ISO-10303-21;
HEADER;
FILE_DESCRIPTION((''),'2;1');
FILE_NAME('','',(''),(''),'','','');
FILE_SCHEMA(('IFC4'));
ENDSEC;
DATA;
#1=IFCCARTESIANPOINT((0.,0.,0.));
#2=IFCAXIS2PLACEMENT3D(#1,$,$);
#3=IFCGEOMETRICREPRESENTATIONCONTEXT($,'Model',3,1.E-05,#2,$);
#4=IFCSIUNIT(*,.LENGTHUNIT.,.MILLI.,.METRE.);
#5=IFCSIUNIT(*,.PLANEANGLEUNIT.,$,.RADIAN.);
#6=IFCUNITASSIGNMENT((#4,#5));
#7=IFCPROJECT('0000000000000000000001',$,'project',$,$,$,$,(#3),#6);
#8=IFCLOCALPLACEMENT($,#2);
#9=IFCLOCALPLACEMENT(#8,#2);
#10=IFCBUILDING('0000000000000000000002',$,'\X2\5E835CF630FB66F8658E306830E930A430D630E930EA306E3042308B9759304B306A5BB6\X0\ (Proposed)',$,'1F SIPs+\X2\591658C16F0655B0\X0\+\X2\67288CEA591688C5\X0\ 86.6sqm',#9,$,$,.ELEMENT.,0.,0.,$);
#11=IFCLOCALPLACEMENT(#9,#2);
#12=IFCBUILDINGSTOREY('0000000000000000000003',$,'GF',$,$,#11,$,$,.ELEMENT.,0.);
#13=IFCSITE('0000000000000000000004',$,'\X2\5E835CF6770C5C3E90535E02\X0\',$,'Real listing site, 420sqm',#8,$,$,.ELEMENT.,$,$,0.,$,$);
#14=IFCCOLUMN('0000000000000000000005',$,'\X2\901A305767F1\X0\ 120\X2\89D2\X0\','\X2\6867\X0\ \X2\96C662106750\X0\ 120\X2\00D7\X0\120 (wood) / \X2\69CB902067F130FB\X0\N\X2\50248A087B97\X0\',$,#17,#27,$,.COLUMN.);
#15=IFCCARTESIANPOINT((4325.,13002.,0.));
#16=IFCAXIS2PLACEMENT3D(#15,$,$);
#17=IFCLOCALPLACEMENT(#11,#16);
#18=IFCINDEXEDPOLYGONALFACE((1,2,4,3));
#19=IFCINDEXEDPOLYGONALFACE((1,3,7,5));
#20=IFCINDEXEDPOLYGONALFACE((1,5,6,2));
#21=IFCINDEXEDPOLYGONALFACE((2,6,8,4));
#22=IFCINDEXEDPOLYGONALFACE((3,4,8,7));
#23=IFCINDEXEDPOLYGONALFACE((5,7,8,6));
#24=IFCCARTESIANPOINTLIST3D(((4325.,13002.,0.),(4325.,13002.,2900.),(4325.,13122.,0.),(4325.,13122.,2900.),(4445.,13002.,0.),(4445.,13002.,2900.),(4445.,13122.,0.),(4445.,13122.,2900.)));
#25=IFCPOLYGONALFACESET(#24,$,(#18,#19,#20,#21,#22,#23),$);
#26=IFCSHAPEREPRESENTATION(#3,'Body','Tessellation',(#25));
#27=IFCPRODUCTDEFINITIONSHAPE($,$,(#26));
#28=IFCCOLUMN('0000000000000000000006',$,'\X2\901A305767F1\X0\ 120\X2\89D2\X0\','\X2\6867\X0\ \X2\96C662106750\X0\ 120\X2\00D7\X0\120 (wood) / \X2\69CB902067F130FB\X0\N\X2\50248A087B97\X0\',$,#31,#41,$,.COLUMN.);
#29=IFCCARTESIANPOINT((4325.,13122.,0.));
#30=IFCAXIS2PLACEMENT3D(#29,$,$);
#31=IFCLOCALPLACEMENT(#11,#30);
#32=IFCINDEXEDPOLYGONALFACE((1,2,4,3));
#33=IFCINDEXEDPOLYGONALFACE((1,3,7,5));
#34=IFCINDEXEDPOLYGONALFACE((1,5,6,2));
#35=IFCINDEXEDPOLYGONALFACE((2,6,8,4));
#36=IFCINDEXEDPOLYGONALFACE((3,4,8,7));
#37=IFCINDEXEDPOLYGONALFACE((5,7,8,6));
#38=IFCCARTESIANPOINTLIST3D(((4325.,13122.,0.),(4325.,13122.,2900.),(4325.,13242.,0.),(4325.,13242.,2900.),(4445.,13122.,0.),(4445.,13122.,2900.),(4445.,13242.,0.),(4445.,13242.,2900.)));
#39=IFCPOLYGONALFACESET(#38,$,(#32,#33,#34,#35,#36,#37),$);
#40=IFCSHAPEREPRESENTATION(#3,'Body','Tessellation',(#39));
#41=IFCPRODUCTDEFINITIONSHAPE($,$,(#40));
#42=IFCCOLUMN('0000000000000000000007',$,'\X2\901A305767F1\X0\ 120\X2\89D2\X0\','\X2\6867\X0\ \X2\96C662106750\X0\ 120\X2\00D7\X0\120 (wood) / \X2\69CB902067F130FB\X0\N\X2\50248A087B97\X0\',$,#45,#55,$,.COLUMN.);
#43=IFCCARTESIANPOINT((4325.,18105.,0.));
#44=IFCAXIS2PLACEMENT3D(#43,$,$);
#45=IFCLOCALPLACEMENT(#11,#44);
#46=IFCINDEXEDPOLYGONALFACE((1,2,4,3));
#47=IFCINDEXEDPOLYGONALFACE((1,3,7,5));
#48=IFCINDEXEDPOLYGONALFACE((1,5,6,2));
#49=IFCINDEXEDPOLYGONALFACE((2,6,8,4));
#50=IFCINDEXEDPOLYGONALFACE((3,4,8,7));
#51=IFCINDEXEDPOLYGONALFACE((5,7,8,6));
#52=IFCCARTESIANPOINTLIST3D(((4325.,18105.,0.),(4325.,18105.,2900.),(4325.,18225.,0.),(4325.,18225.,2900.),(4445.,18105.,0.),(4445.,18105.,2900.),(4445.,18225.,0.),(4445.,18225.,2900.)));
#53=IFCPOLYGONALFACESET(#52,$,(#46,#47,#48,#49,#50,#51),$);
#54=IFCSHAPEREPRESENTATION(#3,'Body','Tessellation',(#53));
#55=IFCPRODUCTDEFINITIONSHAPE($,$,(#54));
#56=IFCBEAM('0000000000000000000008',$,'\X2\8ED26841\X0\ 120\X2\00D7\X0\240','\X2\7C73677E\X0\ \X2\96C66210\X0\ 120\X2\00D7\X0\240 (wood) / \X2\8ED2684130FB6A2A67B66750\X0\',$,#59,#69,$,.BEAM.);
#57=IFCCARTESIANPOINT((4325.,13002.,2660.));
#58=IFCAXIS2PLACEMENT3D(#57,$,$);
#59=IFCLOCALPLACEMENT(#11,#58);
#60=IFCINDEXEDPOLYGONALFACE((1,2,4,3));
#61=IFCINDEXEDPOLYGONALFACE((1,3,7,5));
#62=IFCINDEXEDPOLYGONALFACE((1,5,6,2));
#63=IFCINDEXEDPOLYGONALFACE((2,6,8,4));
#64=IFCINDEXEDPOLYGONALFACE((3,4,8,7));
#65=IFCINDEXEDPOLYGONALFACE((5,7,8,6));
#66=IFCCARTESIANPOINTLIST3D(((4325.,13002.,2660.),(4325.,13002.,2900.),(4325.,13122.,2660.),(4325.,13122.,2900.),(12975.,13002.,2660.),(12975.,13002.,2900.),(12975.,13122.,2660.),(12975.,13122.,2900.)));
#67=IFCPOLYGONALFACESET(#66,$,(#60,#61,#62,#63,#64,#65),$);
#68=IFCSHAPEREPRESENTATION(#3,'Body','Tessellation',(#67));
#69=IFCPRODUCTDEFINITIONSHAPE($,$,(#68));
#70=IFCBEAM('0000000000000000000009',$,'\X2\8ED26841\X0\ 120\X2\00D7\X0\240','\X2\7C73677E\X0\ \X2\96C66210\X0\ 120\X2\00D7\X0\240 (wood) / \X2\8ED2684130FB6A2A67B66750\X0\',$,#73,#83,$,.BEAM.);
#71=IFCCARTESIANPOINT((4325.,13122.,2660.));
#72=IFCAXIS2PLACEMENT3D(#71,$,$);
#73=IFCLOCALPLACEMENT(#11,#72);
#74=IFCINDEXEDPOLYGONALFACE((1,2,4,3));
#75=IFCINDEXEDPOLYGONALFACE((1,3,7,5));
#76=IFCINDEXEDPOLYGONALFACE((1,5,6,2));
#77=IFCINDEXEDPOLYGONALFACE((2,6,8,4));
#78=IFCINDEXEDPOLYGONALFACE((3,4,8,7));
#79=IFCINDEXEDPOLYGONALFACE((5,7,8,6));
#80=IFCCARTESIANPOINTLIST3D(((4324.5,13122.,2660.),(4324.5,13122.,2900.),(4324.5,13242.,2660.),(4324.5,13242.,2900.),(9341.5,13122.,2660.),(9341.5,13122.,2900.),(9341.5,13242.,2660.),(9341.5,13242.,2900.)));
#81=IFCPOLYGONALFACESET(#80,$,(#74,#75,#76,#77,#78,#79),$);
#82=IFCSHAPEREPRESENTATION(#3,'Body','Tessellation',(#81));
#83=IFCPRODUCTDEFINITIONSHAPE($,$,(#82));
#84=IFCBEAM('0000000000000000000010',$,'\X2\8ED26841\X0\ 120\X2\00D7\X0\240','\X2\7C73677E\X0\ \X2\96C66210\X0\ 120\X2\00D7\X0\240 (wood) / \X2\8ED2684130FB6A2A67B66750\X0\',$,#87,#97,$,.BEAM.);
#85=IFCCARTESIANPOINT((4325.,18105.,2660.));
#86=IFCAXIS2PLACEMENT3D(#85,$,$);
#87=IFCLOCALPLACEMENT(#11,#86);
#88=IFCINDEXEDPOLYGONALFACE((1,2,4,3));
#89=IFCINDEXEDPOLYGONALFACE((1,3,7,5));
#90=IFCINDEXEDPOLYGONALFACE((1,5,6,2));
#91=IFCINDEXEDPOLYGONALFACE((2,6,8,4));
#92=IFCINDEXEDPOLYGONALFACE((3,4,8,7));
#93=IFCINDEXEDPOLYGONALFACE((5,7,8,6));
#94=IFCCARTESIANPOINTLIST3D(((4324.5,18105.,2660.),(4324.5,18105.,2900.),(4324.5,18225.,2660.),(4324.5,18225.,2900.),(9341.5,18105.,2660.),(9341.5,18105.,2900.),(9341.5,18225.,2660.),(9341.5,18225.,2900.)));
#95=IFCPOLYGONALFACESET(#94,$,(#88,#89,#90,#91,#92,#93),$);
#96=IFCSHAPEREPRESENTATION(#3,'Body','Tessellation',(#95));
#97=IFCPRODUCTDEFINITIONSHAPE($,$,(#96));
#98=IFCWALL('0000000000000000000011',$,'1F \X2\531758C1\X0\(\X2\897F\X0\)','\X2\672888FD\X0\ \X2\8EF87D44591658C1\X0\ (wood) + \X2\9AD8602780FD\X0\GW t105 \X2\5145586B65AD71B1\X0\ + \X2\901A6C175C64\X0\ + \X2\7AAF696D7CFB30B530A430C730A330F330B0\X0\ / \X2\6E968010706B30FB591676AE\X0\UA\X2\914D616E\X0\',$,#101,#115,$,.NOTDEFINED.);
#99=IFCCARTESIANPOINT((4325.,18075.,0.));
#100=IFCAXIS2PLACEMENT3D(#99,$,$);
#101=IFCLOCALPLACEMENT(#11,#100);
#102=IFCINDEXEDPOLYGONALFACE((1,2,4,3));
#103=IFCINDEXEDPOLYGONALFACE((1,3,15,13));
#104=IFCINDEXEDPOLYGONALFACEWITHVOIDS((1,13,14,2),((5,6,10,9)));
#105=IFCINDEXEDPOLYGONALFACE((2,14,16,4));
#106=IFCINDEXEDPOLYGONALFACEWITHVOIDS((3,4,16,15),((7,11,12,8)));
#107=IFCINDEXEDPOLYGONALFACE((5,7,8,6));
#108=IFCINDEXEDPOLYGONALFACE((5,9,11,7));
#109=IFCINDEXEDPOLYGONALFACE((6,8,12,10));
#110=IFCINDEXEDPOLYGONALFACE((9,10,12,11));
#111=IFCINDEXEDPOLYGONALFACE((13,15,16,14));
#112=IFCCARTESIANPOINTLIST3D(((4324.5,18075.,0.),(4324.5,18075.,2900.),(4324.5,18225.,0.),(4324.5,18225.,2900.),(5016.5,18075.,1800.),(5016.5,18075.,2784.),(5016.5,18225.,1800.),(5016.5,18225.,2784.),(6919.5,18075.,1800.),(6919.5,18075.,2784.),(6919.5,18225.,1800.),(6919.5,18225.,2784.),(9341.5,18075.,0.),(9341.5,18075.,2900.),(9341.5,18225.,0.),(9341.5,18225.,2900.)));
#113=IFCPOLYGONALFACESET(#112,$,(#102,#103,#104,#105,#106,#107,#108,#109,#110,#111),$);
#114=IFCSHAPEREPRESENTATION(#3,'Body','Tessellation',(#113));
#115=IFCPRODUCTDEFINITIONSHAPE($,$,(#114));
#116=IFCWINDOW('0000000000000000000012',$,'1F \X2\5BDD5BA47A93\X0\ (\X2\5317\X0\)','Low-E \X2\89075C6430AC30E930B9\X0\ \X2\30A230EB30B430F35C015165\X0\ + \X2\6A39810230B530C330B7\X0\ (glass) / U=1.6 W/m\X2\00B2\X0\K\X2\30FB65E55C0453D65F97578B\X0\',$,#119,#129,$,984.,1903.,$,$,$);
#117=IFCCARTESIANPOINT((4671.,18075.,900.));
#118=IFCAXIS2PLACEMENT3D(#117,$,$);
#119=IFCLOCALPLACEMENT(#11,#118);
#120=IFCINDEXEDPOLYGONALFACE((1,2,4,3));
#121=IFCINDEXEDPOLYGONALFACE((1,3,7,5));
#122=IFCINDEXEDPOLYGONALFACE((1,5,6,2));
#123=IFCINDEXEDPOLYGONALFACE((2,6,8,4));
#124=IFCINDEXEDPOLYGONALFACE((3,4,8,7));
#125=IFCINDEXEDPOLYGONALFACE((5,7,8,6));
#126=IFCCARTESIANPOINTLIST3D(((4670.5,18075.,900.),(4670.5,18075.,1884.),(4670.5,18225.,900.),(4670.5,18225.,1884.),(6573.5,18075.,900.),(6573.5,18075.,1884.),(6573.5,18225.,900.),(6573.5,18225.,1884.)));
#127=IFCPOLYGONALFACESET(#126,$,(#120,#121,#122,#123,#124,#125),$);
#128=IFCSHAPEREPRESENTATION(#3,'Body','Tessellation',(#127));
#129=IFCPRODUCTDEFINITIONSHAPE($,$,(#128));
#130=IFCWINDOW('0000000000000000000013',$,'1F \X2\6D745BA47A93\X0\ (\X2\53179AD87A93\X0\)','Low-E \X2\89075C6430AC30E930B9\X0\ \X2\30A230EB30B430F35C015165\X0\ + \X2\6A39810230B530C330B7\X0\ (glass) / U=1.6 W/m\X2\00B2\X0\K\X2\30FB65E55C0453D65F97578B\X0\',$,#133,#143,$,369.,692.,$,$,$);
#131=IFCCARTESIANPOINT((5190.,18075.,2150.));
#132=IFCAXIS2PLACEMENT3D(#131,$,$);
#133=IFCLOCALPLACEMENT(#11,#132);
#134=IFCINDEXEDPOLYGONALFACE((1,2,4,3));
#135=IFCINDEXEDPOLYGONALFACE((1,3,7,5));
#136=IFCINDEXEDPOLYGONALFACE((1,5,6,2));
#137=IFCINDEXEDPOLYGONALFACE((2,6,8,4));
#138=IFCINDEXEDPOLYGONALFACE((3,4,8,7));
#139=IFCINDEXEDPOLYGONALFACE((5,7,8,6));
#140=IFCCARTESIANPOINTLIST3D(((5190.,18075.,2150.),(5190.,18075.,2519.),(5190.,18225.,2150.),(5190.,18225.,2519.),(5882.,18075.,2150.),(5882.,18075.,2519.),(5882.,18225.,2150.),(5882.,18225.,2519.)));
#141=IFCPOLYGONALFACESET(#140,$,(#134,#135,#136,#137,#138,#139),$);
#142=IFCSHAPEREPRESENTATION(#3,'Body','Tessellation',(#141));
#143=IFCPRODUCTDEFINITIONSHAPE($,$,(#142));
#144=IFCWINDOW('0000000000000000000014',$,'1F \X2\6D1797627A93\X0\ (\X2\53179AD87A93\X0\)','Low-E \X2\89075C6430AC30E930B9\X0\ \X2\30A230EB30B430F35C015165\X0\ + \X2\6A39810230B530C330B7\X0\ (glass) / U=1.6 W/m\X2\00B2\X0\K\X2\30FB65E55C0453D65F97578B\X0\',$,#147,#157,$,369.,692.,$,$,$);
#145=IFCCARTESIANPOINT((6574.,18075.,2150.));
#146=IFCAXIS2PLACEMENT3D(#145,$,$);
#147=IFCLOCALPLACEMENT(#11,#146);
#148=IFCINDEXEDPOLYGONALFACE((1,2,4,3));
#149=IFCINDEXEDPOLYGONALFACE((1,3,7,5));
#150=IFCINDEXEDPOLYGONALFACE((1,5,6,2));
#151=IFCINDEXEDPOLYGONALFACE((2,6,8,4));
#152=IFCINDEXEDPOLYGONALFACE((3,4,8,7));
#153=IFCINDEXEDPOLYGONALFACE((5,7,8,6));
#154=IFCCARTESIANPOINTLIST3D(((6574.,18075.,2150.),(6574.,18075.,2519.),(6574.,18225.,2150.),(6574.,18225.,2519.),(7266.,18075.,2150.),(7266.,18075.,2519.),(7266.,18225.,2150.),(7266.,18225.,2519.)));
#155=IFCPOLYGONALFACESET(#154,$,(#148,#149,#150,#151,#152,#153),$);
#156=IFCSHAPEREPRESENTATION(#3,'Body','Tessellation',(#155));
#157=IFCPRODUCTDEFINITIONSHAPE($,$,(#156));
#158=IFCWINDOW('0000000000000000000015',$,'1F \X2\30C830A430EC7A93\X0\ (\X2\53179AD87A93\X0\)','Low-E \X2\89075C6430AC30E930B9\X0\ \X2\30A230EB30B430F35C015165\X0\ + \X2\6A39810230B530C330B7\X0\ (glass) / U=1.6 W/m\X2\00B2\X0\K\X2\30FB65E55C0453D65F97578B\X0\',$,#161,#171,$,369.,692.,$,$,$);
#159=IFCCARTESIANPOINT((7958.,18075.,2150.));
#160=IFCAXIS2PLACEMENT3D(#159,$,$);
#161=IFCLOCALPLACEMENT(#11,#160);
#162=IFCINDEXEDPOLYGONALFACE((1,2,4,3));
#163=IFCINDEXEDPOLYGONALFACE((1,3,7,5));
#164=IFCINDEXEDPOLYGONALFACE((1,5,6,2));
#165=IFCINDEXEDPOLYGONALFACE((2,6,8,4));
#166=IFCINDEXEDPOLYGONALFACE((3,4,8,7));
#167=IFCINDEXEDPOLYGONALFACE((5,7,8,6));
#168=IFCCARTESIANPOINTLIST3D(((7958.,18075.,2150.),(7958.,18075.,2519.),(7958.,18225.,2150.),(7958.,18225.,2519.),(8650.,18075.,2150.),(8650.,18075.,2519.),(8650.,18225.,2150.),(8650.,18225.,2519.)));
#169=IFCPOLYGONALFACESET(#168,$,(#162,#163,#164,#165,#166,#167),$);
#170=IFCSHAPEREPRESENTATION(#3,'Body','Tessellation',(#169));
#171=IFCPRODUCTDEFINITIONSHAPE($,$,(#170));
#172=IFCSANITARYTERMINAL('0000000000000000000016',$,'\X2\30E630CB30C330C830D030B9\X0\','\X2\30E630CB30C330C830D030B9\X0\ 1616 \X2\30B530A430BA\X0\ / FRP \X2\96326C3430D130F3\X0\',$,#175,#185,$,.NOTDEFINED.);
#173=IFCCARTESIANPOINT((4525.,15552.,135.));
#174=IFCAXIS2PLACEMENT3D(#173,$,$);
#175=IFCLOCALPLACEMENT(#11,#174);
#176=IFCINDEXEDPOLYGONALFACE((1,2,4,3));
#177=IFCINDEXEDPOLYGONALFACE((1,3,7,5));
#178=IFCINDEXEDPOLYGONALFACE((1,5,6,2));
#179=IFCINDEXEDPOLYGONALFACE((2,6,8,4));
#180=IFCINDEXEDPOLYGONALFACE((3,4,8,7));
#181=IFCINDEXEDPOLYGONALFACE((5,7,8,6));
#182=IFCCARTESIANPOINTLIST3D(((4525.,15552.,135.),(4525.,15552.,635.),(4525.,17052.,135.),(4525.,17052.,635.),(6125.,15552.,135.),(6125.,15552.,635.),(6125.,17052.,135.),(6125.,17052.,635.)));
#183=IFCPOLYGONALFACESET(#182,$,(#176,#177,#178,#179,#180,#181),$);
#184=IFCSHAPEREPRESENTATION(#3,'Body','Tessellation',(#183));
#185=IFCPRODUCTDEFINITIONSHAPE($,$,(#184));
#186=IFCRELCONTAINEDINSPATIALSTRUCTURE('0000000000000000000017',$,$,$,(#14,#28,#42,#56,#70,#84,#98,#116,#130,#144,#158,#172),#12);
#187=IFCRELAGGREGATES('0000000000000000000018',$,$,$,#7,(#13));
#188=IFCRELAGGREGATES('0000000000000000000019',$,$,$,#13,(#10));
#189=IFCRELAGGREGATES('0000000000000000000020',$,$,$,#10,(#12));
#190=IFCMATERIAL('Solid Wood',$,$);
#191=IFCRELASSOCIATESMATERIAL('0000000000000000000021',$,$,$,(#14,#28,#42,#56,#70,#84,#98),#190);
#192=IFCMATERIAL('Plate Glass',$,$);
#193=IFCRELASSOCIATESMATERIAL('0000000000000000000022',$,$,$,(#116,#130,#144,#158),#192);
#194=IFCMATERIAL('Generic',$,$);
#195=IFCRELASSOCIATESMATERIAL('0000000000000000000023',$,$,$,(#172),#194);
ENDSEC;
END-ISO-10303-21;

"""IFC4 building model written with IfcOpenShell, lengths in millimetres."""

from ifc_helpers import new_model, si_unit, frame, frame_2d, origin, place, context, project, spatial, rectangle, extrude, material, element, fill, save


model = new_model("IFC4")

# Units and contexts
model_context = context("Model", 3, precision=1e-05, world=origin())
ifc_project = project(units=[si_unit("LENGTHUNIT", "METRE", prefix="MILLI"), si_unit("PLANEANGLEUNIT", "RADIAN")], contexts=[model_context])

# Site, building, storey
site_placement = place(None, origin())
site = spatial("IfcSite", under=ifc_project, at=site_placement, Name="広島県尾道市", ObjectType="Real listing site, 420sqm", CompositionType="ELEMENT", RefElevation=0.0)
building_placement = place(site_placement, origin())
building = spatial("IfcBuilding", under=site, at=building_placement, Name="広島・書斎とライブラリのある静かな家 (Proposed)", ObjectType="1F SIPs+外壁漆喰+木質外装 86.6sqm", CompositionType="ELEMENT", ElevationOfRefHeight=0.0, ElevationOfTerrain=0.0)
storey_placement = place(building_placement, origin())
storey = spatial("IfcBuildingStorey", under=building, at=storey_placement, Name="GF", CompositionType="ELEMENT", Elevation=0.0)

# Columns
ifc_material_1 = material(Name="Solid Wood")
column_1_placement = place(storey_placement, frame((4325.0, 13002.0, 0.0)))
element("IfcColumn", 1, at=column_1_placement, inside=storey, material=ifc_material_1, Name="通し柱 120角", Description="桧 集成材 120×120 (wood) / 構造柱・N値計算", PredefinedType="COLUMN", context=model_context, shape_type="SweptSolid", body=[
    extrude(rectangle(XDim=120.0, YDim=120.0, at=frame_2d((60.0, 60.0))), frame((4325.0, 13002.0, 0.0)), (0.0, 0.0, 1.0), 2900.0),
])
column_2_placement = place(storey_placement, frame((4325.0, 13122.0, 0.0)))
element("IfcColumn", 2, at=column_2_placement, inside=storey, material=ifc_material_1, Name="通し柱 120角", Description="桧 集成材 120×120 (wood) / 構造柱・N値計算", PredefinedType="COLUMN", context=model_context, shape_type="SweptSolid", body=[
    extrude(rectangle(XDim=120.0, YDim=120.0, at=frame_2d((60.0, 60.0))), frame((4325.0, 13122.0, 0.0)), (0.0, 0.0, 1.0), 2900.0),
])
column_3_placement = place(storey_placement, frame((4325.0, 18105.0, 0.0)))
element("IfcColumn", 3, at=column_3_placement, inside=storey, material=ifc_material_1, Name="通し柱 120角", Description="桧 集成材 120×120 (wood) / 構造柱・N値計算", PredefinedType="COLUMN", context=model_context, shape_type="SweptSolid", body=[
    extrude(rectangle(XDim=120.0, YDim=120.0, at=frame_2d((60.0, 60.0))), frame((4325.0, 18105.0, 0.0)), (0.0, 0.0, 1.0), 2900.0),
])

# Beams
beam_1_placement = place(storey_placement, frame((4325.0, 13002.0, 2660.0)))
element("IfcBeam", 4, at=beam_1_placement, inside=storey, material=ifc_material_1, Name="軒桁 120×240", Description="米松 集成 120×240 (wood) / 軒桁・横架材", PredefinedType="BEAM", context=model_context, shape_type="SweptSolid", body=[
    extrude(rectangle(XDim=8650.0, YDim=120.0, at=frame_2d((4325.0, 60.0))), frame((4325.0, 13002.0, 2660.0)), (0.0, 0.0, 1.0), 240.0),
])
beam_2_placement = place(storey_placement, frame((4325.0, 13122.0, 2660.0)))
element("IfcBeam", 5, at=beam_2_placement, inside=storey, material=ifc_material_1, Name="軒桁 120×240", Description="米松 集成 120×240 (wood) / 軒桁・横架材", PredefinedType="BEAM", context=model_context, shape_type="SweptSolid", body=[
    extrude(rectangle(XDim=5017.0, YDim=120.0, at=frame_2d((2508.0, 60.0))), frame((4325.0, 13122.0, 2660.0)), (0.0, 0.0, 1.0), 240.0),
])
beam_3_placement = place(storey_placement, frame((4325.0, 18105.0, 2660.0)))
element("IfcBeam", 6, at=beam_3_placement, inside=storey, material=ifc_material_1, Name="軒桁 120×240", Description="米松 集成 120×240 (wood) / 軒桁・横架材", PredefinedType="BEAM", context=model_context, shape_type="SweptSolid", body=[
    extrude(rectangle(XDim=5017.0, YDim=120.0, at=frame_2d((2508.0, 60.0))), frame((4325.0, 18105.0, 2660.0)), (0.0, 0.0, 1.0), 240.0),
])

# Wall, openings, windows
wall_1_placement = place(storey_placement, frame((4325.0, 18075.0, 0.0)))
wall_1 = element("IfcWall", 7, at=wall_1_placement, inside=storey, material=ifc_material_1, Name="1F 北壁(西)", Description="木製 軸組外壁 (wood) + 高性能GW t105 充填断熱 + 通気層 + 窯業系サイディング / 準耐火・外皮UA配慮", PredefinedType="NOTDEFINED", context=model_context, shape_type="SweptSolid", body=[
    extrude(rectangle(XDim=5017.0, YDim=150.0, at=frame_2d((2508.0, 75.0))), frame((4325.0, 18075.0, 0.0)), (0.0, 0.0, 1.0), 2900.0),
])
opening_1_placement = place(storey_placement, frame((4671.0, 18075.0, 900.0)))
opening_1 = element("IfcOpeningElement", 8, at=opening_1_placement, cuts=wall_1, PredefinedType="NOTDEFINED", context=model_context, shape_type="SweptSolid", body=[
    extrude(rectangle(XDim=1903.0, YDim=150.0, at=frame_2d((951.0, 75.0))), frame((4671.0, 18075.0, 900.0)), (0.0, 0.0, 1.0), 984.0),
])
opening_2_placement = place(storey_placement, frame((5190.0, 18075.0, 2150.0)))
opening_2 = element("IfcOpeningElement", 9, at=opening_2_placement, cuts=wall_1, PredefinedType="NOTDEFINED", context=model_context, shape_type="SweptSolid", body=[
    extrude(rectangle(XDim=692.0, YDim=150.0, at=frame_2d((346.0, 75.0))), frame((5190.0, 18075.0, 2150.0)), (0.0, 0.0, 1.0), 369.0),
])
opening_3_placement = place(storey_placement, frame((6574.0, 18075.0, 2150.0)))
opening_3 = element("IfcOpeningElement", 10, at=opening_3_placement, cuts=wall_1, PredefinedType="NOTDEFINED", context=model_context, shape_type="SweptSolid", body=[
    extrude(rectangle(XDim=692.0, YDim=150.0, at=frame_2d((346.0, 75.0))), frame((6574.0, 18075.0, 2150.0)), (0.0, 0.0, 1.0), 369.0),
])
opening_4_placement = place(storey_placement, frame((7958.0, 18075.0, 2150.0)))
opening_4 = element("IfcOpeningElement", 11, at=opening_4_placement, cuts=wall_1, PredefinedType="NOTDEFINED", context=model_context, shape_type="SweptSolid", body=[
    extrude(rectangle(XDim=692.0, YDim=150.0, at=frame_2d((346.0, 75.0))), frame((7958.0, 18075.0, 2150.0)), (0.0, 0.0, 1.0), 369.0),
])
ifc_material_2 = material(Name="Plate Glass")
window_1_placement = place(storey_placement, frame((4671.0, 18075.0, 900.0)))
window_1 = element("IfcWindow", 12, at=window_1_placement, inside=storey, material=ifc_material_2, Name="1F 寝室窓 (北)", Description="Low-E 複層ガラス アルゴン封入 + 樹脂サッシ (glass) / U=1.6 W/m²K・日射取得型", OverallHeight=984.0, OverallWidth=1903.0, context=model_context, shape_type="SweptSolid", body=[
    extrude(rectangle(XDim=1903.0, YDim=150.0, at=frame_2d((951.0, 75.0))), frame((4671.0, 18075.0, 900.0)), (0.0, 0.0, 1.0), 984.0),
])
fill(opening_1, window_1)
window_2_placement = place(storey_placement, frame((5190.0, 18075.0, 2150.0)))
window_2 = element("IfcWindow", 13, at=window_2_placement, inside=storey, material=ifc_material_2, Name="1F 浴室窓 (北高窓)", Description="Low-E 複層ガラス アルゴン封入 + 樹脂サッシ (glass) / U=1.6 W/m²K・日射取得型", OverallHeight=369.0, OverallWidth=692.0, context=model_context, shape_type="SweptSolid", body=[
    extrude(rectangle(XDim=692.0, YDim=150.0, at=frame_2d((346.0, 75.0))), frame((5190.0, 18075.0, 2150.0)), (0.0, 0.0, 1.0), 369.0),
])
fill(opening_2, window_2)
window_3_placement = place(storey_placement, frame((6574.0, 18075.0, 2150.0)))
window_3 = element("IfcWindow", 14, at=window_3_placement, inside=storey, material=ifc_material_2, Name="1F 洗面窓 (北高窓)", Description="Low-E 複層ガラス アルゴン封入 + 樹脂サッシ (glass) / U=1.6 W/m²K・日射取得型", OverallHeight=369.0, OverallWidth=692.0, context=model_context, shape_type="SweptSolid", body=[
    extrude(rectangle(XDim=692.0, YDim=150.0, at=frame_2d((346.0, 75.0))), frame((6574.0, 18075.0, 2150.0)), (0.0, 0.0, 1.0), 369.0),
])
fill(opening_3, window_3)
window_4_placement = place(storey_placement, frame((7958.0, 18075.0, 2150.0)))
window_4 = element("IfcWindow", 15, at=window_4_placement, inside=storey, material=ifc_material_2, Name="1F トイレ窓 (北高窓)", Description="Low-E 複層ガラス アルゴン封入 + 樹脂サッシ (glass) / U=1.6 W/m²K・日射取得型", OverallHeight=369.0, OverallWidth=692.0, context=model_context, shape_type="SweptSolid", body=[
    extrude(rectangle(XDim=692.0, YDim=150.0, at=frame_2d((346.0, 75.0))), frame((7958.0, 18075.0, 2150.0)), (0.0, 0.0, 1.0), 369.0),
])
fill(opening_4, window_4)

# Shared definitions
ifc_material_3 = material(Name="Generic")

# Sanitary terminal
sanitary_terminal_placement = place(storey_placement, frame((4525.0, 15552.0, 135.0)))
element("IfcSanitaryTerminal", 16, at=sanitary_terminal_placement, inside=storey, material=ifc_material_3, Name="ユニットバス", Description="ユニットバス 1616 サイズ / FRP 防水パン", PredefinedType="NOTDEFINED", context=model_context, shape_type="SweptSolid", body=[
    extrude(rectangle(XDim=1600.0, YDim=1500.0, at=frame_2d((800.0, 750.0))), frame((4525.0, 15552.0, 135.0)), (0.0, 0.0, 1.0), 500.0),
])

save(model, "model.ifc")
